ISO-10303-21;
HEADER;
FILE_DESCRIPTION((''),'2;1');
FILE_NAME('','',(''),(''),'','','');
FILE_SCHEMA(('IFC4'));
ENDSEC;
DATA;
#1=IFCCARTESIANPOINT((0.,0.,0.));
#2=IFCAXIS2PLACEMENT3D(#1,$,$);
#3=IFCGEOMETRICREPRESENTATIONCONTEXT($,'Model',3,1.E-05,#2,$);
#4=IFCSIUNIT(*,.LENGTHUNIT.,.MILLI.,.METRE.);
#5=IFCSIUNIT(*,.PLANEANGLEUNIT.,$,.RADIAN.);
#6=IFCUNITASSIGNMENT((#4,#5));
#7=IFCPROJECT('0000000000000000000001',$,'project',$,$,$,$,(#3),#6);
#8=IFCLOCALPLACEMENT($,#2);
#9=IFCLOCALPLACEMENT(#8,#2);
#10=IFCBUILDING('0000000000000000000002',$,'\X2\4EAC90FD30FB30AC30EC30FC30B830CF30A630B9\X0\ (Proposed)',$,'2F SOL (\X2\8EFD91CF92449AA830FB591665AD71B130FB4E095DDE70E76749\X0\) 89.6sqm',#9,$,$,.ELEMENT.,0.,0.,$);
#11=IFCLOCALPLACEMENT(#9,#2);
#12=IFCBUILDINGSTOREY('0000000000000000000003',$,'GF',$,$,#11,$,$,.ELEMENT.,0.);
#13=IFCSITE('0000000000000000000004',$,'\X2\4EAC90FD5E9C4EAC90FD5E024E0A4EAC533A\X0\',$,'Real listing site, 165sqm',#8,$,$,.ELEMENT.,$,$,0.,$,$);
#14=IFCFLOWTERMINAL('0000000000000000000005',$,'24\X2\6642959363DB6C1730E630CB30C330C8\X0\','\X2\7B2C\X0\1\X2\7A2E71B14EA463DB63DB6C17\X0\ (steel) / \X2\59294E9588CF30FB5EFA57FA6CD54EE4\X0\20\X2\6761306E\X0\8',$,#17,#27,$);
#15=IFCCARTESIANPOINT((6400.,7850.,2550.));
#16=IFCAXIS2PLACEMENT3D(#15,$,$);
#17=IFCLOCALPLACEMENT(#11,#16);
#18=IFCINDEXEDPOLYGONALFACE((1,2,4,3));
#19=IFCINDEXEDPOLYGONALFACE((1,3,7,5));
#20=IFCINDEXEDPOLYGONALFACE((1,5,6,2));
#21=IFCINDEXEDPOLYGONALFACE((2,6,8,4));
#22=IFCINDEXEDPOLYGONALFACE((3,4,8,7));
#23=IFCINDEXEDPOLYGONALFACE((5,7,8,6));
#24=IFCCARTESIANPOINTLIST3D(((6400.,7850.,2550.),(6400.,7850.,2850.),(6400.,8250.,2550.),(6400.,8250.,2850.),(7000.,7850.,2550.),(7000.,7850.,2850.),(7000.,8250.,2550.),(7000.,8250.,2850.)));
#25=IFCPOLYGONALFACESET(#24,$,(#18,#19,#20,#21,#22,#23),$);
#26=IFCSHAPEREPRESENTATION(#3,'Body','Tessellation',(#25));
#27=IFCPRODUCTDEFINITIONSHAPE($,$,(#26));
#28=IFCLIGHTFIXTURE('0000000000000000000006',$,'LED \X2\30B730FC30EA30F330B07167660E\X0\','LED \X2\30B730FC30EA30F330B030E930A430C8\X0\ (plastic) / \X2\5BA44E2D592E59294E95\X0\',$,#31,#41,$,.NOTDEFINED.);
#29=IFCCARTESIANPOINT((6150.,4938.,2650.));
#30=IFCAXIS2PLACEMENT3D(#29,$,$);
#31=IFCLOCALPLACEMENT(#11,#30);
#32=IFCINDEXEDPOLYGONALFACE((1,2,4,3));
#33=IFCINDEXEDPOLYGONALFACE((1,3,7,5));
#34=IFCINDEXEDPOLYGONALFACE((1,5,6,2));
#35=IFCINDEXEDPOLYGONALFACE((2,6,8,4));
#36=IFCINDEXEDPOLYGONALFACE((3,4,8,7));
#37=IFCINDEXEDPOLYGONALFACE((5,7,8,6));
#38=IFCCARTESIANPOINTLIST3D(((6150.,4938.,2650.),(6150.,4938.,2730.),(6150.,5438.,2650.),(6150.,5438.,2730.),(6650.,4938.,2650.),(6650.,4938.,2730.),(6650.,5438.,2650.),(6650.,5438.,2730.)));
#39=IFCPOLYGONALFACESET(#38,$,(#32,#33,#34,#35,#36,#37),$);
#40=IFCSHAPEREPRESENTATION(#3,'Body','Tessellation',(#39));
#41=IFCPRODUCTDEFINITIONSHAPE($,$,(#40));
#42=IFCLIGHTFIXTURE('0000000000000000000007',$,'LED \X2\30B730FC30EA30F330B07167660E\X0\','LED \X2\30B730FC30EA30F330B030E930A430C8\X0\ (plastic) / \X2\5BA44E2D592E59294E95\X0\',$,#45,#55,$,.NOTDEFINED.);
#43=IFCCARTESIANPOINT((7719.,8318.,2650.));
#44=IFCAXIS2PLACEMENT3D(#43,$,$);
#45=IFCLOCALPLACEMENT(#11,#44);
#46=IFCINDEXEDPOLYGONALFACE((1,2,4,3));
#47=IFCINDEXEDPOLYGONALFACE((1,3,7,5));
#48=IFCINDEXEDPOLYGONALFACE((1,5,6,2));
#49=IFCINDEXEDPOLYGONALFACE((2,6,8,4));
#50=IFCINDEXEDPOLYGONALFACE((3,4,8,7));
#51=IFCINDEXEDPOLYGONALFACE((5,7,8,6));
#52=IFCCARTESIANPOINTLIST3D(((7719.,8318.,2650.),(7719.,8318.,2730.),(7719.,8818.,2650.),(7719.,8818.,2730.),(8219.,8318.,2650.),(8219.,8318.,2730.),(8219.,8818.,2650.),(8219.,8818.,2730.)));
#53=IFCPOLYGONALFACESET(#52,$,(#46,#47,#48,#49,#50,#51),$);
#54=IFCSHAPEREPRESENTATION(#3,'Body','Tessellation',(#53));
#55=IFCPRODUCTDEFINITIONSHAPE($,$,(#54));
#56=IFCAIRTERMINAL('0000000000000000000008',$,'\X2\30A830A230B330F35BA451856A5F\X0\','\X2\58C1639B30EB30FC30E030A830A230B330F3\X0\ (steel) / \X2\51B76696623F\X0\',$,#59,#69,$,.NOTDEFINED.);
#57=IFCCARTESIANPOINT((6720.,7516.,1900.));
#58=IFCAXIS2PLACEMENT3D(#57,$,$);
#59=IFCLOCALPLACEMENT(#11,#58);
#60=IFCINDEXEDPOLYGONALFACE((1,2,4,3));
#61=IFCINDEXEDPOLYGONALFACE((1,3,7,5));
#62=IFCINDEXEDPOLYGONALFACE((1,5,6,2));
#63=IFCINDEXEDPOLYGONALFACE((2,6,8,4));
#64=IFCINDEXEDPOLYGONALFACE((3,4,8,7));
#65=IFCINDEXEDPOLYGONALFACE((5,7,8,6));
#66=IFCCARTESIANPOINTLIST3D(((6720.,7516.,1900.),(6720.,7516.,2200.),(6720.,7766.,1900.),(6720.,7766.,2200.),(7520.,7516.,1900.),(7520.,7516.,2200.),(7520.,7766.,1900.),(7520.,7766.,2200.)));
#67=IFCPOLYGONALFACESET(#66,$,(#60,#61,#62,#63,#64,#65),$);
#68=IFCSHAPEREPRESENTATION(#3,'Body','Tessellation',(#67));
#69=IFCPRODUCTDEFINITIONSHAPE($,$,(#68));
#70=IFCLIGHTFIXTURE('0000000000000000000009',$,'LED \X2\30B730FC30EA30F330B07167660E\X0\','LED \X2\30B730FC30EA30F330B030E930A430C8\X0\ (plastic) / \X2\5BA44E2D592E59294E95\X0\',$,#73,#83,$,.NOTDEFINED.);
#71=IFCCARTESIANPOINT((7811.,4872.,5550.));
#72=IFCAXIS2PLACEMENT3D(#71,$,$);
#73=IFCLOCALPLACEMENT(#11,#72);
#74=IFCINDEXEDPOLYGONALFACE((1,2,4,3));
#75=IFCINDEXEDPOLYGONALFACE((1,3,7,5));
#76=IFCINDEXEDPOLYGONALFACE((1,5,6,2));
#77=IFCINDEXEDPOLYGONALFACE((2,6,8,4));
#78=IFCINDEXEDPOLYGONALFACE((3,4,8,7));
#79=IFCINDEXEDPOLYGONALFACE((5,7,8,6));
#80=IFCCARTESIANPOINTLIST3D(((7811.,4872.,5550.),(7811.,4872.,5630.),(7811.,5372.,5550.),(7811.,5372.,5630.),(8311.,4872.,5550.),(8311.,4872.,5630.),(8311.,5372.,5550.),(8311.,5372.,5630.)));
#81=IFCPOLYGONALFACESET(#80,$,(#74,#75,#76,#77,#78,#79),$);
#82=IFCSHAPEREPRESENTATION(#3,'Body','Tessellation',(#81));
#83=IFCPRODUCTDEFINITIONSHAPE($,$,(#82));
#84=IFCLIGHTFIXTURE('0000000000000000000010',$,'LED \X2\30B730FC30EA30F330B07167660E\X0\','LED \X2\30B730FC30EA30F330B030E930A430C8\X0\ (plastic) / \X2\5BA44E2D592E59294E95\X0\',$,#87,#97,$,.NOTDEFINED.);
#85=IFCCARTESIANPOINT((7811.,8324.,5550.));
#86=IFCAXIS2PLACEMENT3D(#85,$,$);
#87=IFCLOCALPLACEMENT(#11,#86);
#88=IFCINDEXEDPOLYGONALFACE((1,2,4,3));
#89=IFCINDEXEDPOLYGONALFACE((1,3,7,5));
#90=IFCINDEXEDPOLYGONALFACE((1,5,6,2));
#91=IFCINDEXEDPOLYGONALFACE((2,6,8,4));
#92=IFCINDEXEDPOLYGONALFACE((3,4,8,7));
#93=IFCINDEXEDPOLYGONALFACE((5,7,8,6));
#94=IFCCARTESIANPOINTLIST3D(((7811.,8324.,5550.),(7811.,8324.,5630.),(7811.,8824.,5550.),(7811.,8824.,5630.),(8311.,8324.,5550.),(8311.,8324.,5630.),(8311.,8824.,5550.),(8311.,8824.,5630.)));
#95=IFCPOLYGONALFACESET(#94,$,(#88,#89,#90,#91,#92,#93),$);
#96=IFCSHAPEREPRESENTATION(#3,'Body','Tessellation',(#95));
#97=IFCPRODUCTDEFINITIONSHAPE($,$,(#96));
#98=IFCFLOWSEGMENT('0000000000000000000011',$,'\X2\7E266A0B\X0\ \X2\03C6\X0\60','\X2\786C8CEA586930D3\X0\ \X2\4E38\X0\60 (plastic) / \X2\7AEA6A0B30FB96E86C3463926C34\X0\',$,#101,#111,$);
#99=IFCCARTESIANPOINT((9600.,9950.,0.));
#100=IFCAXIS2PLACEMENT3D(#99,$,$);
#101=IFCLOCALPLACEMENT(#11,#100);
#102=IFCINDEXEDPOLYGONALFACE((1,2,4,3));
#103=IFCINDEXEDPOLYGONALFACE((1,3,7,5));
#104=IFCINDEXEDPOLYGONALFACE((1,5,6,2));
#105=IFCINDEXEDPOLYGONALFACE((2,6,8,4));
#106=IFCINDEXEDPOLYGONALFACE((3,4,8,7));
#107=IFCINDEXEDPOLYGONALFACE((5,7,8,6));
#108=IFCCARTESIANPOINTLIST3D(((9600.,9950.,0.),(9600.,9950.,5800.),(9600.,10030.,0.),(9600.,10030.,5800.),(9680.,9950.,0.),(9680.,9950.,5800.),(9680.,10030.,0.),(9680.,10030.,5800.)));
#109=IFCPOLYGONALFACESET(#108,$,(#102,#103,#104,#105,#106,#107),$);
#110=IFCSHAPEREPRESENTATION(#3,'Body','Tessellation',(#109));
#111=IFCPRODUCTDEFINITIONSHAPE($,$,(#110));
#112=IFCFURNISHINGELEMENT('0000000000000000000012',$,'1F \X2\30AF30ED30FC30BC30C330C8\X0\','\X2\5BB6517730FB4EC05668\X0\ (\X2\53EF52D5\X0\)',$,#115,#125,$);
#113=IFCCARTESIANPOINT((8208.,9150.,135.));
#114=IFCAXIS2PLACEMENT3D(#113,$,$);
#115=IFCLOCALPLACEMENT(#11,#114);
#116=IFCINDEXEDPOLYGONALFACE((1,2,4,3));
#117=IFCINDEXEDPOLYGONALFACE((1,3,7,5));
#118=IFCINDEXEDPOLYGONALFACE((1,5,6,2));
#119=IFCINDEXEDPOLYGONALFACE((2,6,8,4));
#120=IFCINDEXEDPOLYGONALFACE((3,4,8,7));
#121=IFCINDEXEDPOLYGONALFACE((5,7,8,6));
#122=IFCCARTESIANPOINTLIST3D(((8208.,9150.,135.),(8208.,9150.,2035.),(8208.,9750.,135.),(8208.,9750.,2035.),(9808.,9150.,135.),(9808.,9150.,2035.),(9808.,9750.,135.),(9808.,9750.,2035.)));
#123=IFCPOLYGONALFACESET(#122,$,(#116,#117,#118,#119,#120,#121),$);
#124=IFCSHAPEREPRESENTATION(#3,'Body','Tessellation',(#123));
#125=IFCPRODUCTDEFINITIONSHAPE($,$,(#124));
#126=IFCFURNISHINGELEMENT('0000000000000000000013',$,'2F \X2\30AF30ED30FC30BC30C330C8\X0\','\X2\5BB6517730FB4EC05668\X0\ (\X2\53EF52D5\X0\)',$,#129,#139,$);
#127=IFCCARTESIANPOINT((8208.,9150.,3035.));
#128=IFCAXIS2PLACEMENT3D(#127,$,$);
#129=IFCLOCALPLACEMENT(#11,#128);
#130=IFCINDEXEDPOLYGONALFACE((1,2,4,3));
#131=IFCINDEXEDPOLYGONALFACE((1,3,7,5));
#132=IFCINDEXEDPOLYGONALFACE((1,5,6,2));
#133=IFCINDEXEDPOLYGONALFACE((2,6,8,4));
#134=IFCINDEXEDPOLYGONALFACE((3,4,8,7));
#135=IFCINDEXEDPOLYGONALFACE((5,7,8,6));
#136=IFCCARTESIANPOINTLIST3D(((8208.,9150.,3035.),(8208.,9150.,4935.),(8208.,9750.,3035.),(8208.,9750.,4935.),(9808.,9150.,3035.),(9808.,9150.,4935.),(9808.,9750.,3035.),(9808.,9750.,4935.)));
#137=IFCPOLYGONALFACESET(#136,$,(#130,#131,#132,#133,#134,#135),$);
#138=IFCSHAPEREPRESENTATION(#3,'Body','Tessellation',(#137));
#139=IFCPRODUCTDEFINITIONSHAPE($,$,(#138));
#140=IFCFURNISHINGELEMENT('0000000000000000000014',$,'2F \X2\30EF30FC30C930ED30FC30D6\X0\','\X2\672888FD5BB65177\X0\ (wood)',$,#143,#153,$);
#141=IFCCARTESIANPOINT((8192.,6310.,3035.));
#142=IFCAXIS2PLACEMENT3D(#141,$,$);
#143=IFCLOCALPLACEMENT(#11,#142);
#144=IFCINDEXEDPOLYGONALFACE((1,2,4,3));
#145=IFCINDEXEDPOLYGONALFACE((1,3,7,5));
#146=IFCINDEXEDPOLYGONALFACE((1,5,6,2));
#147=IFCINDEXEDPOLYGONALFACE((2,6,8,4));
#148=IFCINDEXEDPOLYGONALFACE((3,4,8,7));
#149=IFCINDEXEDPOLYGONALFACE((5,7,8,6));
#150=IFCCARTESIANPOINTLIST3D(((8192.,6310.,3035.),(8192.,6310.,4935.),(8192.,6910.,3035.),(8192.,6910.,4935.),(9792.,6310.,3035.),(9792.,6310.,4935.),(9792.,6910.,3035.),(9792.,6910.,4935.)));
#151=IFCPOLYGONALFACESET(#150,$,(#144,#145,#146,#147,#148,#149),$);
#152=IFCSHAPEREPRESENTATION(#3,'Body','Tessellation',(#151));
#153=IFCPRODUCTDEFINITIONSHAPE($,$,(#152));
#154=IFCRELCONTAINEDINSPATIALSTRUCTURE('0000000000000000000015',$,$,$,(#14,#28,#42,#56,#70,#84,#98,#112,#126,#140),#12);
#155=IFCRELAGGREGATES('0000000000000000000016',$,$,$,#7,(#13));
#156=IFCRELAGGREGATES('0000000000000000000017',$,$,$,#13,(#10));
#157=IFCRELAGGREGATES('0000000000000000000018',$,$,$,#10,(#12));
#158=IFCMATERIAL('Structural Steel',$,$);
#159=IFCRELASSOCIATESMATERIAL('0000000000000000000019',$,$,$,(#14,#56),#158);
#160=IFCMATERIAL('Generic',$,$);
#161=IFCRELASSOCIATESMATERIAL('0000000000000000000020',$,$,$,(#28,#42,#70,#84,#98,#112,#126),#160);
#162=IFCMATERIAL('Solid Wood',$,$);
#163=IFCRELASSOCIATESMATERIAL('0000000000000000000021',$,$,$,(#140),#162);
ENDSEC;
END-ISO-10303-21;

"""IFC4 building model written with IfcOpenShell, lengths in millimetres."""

from ifc_helpers import new_model, si_unit, frame, frame_2d, origin, place, context, project, spatial, rectangle, extrude, material, element, save


model = new_model("IFC4")

# Units and contexts
model_context = context("Model", 3, precision=1e-05, world=origin())
ifc_project = project(units=[si_unit("LENGTHUNIT", "METRE", prefix="MILLI"), si_unit("PLANEANGLEUNIT", "RADIAN")], contexts=[model_context])

# Site, building, storey
site_placement = place(None, origin())
site = spatial("IfcSite", under=ifc_project, at=site_placement, Name="京都府京都市上京区", ObjectType="Real listing site, 165sqm", CompositionType="ELEMENT", RefElevation=0.0)
building_placement = place(site_placement, origin())
building = spatial("IfcBuilding", under=site, at=building_placement, Name="京都・ガレージハウス (Proposed)", ObjectType="2F SOL (軽量鉄骨・外断熱・三州烧杉) 89.6sqm", CompositionType="ELEMENT", ElevationOfRefHeight=0.0, ElevationOfTerrain=0.0)
storey_placement = place(building_placement, origin())
storey = spatial("IfcBuildingStorey", under=building, at=storey_placement, Name="GF", CompositionType="ELEMENT", Elevation=0.0)

# Shared definitions
ifc_material_1 = material(Name="Solid Wood")
ifc_material_2 = material(Name="Structural Steel")

# Shared definitions
ifc_material_3 = material(Name="Generic")

# Flow terminal
flow_terminal_placement = place(storey_placement, frame((6400.0, 7850.0, 2550.0)))
element("IfcFlowTerminal", 1, at=flow_terminal_placement, inside=storey, material=ifc_material_2, Name="24時間換気ユニット", Description="第1種熱交換換気 (steel) / 天井裏・建基法令20条の8", context=model_context, shape_type="SweptSolid", body=[
    extrude(rectangle(XDim=600.0, YDim=400.0, at=frame_2d((300.0, 200.0))), frame((6400.0, 7850.0, 2550.0)), (0.0, 0.0, 1.0), 300.0),
])

# Light fixtures
light_fixture_1_placement = place(storey_placement, frame((6150.0, 4938.0, 2650.0)))
element("IfcLightFixture", 2, at=light_fixture_1_placement, inside=storey, material=ifc_material_3, Name="LED シーリング照明", Description="LED シーリングライト (plastic) / 室中央天井", PredefinedType="NOTDEFINED", context=model_context, shape_type="SweptSolid", body=[
    extrude(rectangle(XDim=500.0, YDim=500.0, at=frame_2d((250.0, 250.0))), frame((6150.0, 4938.0, 2650.0)), (0.0, 0.0, 1.0), 80.0),
])
light_fixture_2_placement = place(storey_placement, frame((7719.0, 8318.0, 2650.0)))
element("IfcLightFixture", 3, at=light_fixture_2_placement, inside=storey, material=ifc_material_3, Name="LED シーリング照明", Description="LED シーリングライト (plastic) / 室中央天井", PredefinedType="NOTDEFINED", context=model_context, shape_type="SweptSolid", body=[
    extrude(rectangle(XDim=500.0, YDim=500.0, at=frame_2d((250.0, 250.0))), frame((7719.0, 8318.0, 2650.0)), (0.0, 0.0, 1.0), 80.0),
])

# Air terminal
air_terminal_placement = place(storey_placement, frame((6720.0, 7516.0, 1900.0)))
element("IfcAirTerminal", 4, at=air_terminal_placement, inside=storey, material=ifc_material_2, Name="エアコン室内機", Description="壁掛ルームエアコン (steel) / 冷暖房", PredefinedType="NOTDEFINED", context=model_context, shape_type="SweptSolid", body=[
    extrude(rectangle(XDim=800.0, YDim=250.0, at=frame_2d((400.0, 125.0))), frame((6720.0, 7516.0, 1900.0)), (0.0, 0.0, 1.0), 300.0),
])

# Light fixtures
light_fixture_3_placement = place(storey_placement, frame((7811.0, 4872.0, 5550.0)))
element("IfcLightFixture", 5, at=light_fixture_3_placement, inside=storey, material=ifc_material_3, Name="LED シーリング照明", Description="LED シーリングライト (plastic) / 室中央天井", PredefinedType="NOTDEFINED", context=model_context, shape_type="SweptSolid", body=[
    extrude(rectangle(XDim=500.0, YDim=500.0, at=frame_2d((250.0, 250.0))), frame((7811.0, 4872.0, 5550.0)), (0.0, 0.0, 1.0), 80.0),
])
light_fixture_4_placement = place(storey_placement, frame((7811.0, 8324.0, 5550.0)))
element("IfcLightFixture", 6, at=light_fixture_4_placement, inside=storey, material=ifc_material_3, Name="LED シーリング照明", Description="LED シーリングライト (plastic) / 室中央天井", PredefinedType="NOTDEFINED", context=model_context, shape_type="SweptSolid", body=[
    extrude(rectangle(XDim=500.0, YDim=500.0, at=frame_2d((250.0, 250.0))), frame((7811.0, 8324.0, 5550.0)), (0.0, 0.0, 1.0), 80.0),
])

# Flow segment
flow_segment_placement = place(storey_placement, frame((9600.0, 9950.0, 0.0)))
element("IfcFlowSegment", 7, at=flow_segment_placement, inside=storey, material=ifc_material_3, Name="縦樋 φ60", Description="硬質塩ビ 丸60 (plastic) / 竪樋・雨水排水", context=model_context, shape_type="SweptSolid", body=[
    extrude(rectangle(XDim=80.0, YDim=80.0, at=frame_2d((40.0, 40.0))), frame((9600.0, 9950.0, 0.0)), (0.0, 0.0, 1.0), 5800.0),
])

# Furnishing elements
furnishing_1_placement = place(storey_placement, frame((8208.0, 9150.0, 135.0)))
element("IfcFurnishingElement", 8, at=furnishing_1_placement, inside=storey, material=ifc_material_3, Name="1F クローゼット", Description="家具・什器 (可動)", context=model_context, shape_type="SweptSolid", body=[
    extrude(rectangle(XDim=1600.0, YDim=600.0, at=frame_2d((800.0, 300.0))), frame((8208.0, 9150.0, 135.0)), (0.0, 0.0, 1.0), 1900.0),
])
furnishing_2_placement = place(storey_placement, frame((8208.0, 9150.0, 3035.0)))
element("IfcFurnishingElement", 9, at=furnishing_2_placement, inside=storey, material=ifc_material_3, Name="2F クローゼット", Description="家具・什器 (可動)", context=model_context, shape_type="SweptSolid", body=[
    extrude(rectangle(XDim=1600.0, YDim=600.0, at=frame_2d((800.0, 300.0))), frame((8208.0, 9150.0, 3035.0)), (0.0, 0.0, 1.0), 1900.0),
])
furnishing_3_placement = place(storey_placement, frame((8192.0, 6310.0, 3035.0)))
element("IfcFurnishingElement", 10, at=furnishing_3_placement, inside=storey, material=ifc_material_1, Name="2F ワードローブ", Description="木製家具 (wood)", context=model_context, shape_type="SweptSolid", body=[
    extrude(rectangle(XDim=1600.0, YDim=600.0, at=frame_2d((800.0, 300.0))), frame((8192.0, 6310.0, 3035.0)), (0.0, 0.0, 1.0), 1900.0),
])

save(model, "model.ifc")
